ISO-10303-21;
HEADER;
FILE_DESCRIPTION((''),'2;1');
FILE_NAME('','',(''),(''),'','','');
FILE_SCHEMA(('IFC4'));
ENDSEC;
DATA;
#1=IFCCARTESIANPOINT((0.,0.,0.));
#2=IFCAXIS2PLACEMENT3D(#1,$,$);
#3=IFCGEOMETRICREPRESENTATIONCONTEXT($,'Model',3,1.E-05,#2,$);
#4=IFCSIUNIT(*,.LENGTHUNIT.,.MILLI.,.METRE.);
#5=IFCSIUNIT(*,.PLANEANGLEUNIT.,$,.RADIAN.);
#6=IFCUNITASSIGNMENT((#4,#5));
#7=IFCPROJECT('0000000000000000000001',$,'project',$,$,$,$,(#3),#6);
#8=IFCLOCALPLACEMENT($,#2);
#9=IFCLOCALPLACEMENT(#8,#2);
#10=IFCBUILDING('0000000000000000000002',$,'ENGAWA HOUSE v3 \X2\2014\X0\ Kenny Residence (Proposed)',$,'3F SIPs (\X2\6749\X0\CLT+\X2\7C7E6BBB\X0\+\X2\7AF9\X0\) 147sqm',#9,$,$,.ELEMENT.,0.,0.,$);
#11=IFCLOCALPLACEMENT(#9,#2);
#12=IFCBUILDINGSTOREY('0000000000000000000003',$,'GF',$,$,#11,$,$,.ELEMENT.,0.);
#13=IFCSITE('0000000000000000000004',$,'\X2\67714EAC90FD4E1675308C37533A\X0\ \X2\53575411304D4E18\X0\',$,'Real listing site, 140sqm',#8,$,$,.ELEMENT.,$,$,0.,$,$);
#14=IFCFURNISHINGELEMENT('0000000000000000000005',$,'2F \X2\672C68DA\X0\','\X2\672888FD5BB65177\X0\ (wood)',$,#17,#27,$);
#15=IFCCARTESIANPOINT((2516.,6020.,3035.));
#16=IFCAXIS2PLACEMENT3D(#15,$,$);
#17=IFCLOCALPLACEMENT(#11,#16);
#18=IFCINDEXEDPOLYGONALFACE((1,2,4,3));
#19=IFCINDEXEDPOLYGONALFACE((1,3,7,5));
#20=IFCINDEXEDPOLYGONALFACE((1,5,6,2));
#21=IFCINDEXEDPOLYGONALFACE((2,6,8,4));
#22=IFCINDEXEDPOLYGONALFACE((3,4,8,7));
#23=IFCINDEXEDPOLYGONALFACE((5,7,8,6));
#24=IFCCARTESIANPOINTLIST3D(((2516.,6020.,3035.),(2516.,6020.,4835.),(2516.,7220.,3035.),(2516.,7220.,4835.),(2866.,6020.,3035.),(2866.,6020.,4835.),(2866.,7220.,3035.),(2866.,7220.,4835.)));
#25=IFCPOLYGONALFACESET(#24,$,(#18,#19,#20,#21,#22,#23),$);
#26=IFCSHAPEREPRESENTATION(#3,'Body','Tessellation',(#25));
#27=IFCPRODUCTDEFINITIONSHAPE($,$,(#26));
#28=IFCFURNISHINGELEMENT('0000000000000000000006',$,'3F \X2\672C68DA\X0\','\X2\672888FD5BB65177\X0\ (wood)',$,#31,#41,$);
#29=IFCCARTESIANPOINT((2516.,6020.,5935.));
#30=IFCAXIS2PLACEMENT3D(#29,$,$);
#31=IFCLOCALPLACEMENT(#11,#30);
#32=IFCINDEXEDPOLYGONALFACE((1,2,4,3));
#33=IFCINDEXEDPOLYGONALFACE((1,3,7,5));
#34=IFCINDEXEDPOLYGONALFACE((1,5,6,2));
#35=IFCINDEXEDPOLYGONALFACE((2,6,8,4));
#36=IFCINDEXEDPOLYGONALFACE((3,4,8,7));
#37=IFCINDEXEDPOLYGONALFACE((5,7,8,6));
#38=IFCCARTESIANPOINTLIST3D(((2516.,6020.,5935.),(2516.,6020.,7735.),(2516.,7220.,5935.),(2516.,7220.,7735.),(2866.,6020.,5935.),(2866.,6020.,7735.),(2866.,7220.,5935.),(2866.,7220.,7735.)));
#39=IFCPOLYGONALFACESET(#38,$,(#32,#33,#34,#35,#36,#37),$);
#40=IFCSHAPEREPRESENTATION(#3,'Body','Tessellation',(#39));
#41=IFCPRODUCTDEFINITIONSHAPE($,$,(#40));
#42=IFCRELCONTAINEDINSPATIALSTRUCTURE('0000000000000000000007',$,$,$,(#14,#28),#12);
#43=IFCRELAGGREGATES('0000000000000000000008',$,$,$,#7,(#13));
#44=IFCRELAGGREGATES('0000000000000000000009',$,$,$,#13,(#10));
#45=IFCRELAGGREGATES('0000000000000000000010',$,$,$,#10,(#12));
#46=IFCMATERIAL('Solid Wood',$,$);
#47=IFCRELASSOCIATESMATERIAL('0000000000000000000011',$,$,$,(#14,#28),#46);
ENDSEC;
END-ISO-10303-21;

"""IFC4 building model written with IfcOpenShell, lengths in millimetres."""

from ifc_helpers import new_model, si_unit, frame, frame_2d, origin, place, context, project, spatial, rectangle, extrude, material, element, save


model = new_model("IFC4")

# Units and contexts
model_context = context("Model", 3, precision=1e-05, world=origin())
ifc_project = project(units=[si_unit("LENGTHUNIT", "METRE", prefix="MILLI"), si_unit("PLANEANGLEUNIT", "RADIAN")], contexts=[model_context])

# Site, building, storey
site_placement = place(None, origin())
site = spatial("IfcSite", under=ifc_project, at=site_placement, Name="東京都世田谷区 南向き丘", ObjectType="Real listing site, 140sqm", CompositionType="ELEMENT", RefElevation=0.0)
building_placement = place(site_placement, origin())
building = spatial("IfcBuilding", under=site, at=building_placement, Name="ENGAWA HOUSE v3 — Kenny Residence (Proposed)", ObjectType="3F SIPs (杉CLT+籾殻+竹) 147sqm", CompositionType="ELEMENT", ElevationOfRefHeight=0.0, ElevationOfTerrain=0.0)
storey_placement = place(building_placement, origin())
storey = spatial("IfcBuildingStorey", under=building, at=storey_placement, Name="GF", CompositionType="ELEMENT", Elevation=0.0)

# Shared definitions
ifc_material_1 = material(Name="Solid Wood")

# Furnishing elements
furnishing_1_placement = place(storey_placement, frame((2516.0, 6020.0, 3035.0)))
element("IfcFurnishingElement", 1, at=furnishing_1_placement, inside=storey, material=ifc_material_1, Name="2F 本棚", Description="木製家具 (wood)", context=model_context, shape_type="SweptSolid", body=[
    extrude(rectangle(XDim=350.0, YDim=1200.0, at=frame_2d((175.0, 600.0))), frame((2516.0, 6020.0, 3035.0)), (0.0, 0.0, 1.0), 1800.0),
])
furnishing_2_placement = place(storey_placement, frame((2516.0, 6020.0, 5935.0)))
element("IfcFurnishingElement", 2, at=furnishing_2_placement, inside=storey, material=ifc_material_1, Name="3F 本棚", Description="木製家具 (wood)", context=model_context, shape_type="SweptSolid", body=[
    extrude(rectangle(XDim=350.0, YDim=1200.0, at=frame_2d((175.0, 600.0))), frame((2516.0, 6020.0, 5935.0)), (0.0, 0.0, 1.0), 1800.0),
])

save(model, "model.ifc")
